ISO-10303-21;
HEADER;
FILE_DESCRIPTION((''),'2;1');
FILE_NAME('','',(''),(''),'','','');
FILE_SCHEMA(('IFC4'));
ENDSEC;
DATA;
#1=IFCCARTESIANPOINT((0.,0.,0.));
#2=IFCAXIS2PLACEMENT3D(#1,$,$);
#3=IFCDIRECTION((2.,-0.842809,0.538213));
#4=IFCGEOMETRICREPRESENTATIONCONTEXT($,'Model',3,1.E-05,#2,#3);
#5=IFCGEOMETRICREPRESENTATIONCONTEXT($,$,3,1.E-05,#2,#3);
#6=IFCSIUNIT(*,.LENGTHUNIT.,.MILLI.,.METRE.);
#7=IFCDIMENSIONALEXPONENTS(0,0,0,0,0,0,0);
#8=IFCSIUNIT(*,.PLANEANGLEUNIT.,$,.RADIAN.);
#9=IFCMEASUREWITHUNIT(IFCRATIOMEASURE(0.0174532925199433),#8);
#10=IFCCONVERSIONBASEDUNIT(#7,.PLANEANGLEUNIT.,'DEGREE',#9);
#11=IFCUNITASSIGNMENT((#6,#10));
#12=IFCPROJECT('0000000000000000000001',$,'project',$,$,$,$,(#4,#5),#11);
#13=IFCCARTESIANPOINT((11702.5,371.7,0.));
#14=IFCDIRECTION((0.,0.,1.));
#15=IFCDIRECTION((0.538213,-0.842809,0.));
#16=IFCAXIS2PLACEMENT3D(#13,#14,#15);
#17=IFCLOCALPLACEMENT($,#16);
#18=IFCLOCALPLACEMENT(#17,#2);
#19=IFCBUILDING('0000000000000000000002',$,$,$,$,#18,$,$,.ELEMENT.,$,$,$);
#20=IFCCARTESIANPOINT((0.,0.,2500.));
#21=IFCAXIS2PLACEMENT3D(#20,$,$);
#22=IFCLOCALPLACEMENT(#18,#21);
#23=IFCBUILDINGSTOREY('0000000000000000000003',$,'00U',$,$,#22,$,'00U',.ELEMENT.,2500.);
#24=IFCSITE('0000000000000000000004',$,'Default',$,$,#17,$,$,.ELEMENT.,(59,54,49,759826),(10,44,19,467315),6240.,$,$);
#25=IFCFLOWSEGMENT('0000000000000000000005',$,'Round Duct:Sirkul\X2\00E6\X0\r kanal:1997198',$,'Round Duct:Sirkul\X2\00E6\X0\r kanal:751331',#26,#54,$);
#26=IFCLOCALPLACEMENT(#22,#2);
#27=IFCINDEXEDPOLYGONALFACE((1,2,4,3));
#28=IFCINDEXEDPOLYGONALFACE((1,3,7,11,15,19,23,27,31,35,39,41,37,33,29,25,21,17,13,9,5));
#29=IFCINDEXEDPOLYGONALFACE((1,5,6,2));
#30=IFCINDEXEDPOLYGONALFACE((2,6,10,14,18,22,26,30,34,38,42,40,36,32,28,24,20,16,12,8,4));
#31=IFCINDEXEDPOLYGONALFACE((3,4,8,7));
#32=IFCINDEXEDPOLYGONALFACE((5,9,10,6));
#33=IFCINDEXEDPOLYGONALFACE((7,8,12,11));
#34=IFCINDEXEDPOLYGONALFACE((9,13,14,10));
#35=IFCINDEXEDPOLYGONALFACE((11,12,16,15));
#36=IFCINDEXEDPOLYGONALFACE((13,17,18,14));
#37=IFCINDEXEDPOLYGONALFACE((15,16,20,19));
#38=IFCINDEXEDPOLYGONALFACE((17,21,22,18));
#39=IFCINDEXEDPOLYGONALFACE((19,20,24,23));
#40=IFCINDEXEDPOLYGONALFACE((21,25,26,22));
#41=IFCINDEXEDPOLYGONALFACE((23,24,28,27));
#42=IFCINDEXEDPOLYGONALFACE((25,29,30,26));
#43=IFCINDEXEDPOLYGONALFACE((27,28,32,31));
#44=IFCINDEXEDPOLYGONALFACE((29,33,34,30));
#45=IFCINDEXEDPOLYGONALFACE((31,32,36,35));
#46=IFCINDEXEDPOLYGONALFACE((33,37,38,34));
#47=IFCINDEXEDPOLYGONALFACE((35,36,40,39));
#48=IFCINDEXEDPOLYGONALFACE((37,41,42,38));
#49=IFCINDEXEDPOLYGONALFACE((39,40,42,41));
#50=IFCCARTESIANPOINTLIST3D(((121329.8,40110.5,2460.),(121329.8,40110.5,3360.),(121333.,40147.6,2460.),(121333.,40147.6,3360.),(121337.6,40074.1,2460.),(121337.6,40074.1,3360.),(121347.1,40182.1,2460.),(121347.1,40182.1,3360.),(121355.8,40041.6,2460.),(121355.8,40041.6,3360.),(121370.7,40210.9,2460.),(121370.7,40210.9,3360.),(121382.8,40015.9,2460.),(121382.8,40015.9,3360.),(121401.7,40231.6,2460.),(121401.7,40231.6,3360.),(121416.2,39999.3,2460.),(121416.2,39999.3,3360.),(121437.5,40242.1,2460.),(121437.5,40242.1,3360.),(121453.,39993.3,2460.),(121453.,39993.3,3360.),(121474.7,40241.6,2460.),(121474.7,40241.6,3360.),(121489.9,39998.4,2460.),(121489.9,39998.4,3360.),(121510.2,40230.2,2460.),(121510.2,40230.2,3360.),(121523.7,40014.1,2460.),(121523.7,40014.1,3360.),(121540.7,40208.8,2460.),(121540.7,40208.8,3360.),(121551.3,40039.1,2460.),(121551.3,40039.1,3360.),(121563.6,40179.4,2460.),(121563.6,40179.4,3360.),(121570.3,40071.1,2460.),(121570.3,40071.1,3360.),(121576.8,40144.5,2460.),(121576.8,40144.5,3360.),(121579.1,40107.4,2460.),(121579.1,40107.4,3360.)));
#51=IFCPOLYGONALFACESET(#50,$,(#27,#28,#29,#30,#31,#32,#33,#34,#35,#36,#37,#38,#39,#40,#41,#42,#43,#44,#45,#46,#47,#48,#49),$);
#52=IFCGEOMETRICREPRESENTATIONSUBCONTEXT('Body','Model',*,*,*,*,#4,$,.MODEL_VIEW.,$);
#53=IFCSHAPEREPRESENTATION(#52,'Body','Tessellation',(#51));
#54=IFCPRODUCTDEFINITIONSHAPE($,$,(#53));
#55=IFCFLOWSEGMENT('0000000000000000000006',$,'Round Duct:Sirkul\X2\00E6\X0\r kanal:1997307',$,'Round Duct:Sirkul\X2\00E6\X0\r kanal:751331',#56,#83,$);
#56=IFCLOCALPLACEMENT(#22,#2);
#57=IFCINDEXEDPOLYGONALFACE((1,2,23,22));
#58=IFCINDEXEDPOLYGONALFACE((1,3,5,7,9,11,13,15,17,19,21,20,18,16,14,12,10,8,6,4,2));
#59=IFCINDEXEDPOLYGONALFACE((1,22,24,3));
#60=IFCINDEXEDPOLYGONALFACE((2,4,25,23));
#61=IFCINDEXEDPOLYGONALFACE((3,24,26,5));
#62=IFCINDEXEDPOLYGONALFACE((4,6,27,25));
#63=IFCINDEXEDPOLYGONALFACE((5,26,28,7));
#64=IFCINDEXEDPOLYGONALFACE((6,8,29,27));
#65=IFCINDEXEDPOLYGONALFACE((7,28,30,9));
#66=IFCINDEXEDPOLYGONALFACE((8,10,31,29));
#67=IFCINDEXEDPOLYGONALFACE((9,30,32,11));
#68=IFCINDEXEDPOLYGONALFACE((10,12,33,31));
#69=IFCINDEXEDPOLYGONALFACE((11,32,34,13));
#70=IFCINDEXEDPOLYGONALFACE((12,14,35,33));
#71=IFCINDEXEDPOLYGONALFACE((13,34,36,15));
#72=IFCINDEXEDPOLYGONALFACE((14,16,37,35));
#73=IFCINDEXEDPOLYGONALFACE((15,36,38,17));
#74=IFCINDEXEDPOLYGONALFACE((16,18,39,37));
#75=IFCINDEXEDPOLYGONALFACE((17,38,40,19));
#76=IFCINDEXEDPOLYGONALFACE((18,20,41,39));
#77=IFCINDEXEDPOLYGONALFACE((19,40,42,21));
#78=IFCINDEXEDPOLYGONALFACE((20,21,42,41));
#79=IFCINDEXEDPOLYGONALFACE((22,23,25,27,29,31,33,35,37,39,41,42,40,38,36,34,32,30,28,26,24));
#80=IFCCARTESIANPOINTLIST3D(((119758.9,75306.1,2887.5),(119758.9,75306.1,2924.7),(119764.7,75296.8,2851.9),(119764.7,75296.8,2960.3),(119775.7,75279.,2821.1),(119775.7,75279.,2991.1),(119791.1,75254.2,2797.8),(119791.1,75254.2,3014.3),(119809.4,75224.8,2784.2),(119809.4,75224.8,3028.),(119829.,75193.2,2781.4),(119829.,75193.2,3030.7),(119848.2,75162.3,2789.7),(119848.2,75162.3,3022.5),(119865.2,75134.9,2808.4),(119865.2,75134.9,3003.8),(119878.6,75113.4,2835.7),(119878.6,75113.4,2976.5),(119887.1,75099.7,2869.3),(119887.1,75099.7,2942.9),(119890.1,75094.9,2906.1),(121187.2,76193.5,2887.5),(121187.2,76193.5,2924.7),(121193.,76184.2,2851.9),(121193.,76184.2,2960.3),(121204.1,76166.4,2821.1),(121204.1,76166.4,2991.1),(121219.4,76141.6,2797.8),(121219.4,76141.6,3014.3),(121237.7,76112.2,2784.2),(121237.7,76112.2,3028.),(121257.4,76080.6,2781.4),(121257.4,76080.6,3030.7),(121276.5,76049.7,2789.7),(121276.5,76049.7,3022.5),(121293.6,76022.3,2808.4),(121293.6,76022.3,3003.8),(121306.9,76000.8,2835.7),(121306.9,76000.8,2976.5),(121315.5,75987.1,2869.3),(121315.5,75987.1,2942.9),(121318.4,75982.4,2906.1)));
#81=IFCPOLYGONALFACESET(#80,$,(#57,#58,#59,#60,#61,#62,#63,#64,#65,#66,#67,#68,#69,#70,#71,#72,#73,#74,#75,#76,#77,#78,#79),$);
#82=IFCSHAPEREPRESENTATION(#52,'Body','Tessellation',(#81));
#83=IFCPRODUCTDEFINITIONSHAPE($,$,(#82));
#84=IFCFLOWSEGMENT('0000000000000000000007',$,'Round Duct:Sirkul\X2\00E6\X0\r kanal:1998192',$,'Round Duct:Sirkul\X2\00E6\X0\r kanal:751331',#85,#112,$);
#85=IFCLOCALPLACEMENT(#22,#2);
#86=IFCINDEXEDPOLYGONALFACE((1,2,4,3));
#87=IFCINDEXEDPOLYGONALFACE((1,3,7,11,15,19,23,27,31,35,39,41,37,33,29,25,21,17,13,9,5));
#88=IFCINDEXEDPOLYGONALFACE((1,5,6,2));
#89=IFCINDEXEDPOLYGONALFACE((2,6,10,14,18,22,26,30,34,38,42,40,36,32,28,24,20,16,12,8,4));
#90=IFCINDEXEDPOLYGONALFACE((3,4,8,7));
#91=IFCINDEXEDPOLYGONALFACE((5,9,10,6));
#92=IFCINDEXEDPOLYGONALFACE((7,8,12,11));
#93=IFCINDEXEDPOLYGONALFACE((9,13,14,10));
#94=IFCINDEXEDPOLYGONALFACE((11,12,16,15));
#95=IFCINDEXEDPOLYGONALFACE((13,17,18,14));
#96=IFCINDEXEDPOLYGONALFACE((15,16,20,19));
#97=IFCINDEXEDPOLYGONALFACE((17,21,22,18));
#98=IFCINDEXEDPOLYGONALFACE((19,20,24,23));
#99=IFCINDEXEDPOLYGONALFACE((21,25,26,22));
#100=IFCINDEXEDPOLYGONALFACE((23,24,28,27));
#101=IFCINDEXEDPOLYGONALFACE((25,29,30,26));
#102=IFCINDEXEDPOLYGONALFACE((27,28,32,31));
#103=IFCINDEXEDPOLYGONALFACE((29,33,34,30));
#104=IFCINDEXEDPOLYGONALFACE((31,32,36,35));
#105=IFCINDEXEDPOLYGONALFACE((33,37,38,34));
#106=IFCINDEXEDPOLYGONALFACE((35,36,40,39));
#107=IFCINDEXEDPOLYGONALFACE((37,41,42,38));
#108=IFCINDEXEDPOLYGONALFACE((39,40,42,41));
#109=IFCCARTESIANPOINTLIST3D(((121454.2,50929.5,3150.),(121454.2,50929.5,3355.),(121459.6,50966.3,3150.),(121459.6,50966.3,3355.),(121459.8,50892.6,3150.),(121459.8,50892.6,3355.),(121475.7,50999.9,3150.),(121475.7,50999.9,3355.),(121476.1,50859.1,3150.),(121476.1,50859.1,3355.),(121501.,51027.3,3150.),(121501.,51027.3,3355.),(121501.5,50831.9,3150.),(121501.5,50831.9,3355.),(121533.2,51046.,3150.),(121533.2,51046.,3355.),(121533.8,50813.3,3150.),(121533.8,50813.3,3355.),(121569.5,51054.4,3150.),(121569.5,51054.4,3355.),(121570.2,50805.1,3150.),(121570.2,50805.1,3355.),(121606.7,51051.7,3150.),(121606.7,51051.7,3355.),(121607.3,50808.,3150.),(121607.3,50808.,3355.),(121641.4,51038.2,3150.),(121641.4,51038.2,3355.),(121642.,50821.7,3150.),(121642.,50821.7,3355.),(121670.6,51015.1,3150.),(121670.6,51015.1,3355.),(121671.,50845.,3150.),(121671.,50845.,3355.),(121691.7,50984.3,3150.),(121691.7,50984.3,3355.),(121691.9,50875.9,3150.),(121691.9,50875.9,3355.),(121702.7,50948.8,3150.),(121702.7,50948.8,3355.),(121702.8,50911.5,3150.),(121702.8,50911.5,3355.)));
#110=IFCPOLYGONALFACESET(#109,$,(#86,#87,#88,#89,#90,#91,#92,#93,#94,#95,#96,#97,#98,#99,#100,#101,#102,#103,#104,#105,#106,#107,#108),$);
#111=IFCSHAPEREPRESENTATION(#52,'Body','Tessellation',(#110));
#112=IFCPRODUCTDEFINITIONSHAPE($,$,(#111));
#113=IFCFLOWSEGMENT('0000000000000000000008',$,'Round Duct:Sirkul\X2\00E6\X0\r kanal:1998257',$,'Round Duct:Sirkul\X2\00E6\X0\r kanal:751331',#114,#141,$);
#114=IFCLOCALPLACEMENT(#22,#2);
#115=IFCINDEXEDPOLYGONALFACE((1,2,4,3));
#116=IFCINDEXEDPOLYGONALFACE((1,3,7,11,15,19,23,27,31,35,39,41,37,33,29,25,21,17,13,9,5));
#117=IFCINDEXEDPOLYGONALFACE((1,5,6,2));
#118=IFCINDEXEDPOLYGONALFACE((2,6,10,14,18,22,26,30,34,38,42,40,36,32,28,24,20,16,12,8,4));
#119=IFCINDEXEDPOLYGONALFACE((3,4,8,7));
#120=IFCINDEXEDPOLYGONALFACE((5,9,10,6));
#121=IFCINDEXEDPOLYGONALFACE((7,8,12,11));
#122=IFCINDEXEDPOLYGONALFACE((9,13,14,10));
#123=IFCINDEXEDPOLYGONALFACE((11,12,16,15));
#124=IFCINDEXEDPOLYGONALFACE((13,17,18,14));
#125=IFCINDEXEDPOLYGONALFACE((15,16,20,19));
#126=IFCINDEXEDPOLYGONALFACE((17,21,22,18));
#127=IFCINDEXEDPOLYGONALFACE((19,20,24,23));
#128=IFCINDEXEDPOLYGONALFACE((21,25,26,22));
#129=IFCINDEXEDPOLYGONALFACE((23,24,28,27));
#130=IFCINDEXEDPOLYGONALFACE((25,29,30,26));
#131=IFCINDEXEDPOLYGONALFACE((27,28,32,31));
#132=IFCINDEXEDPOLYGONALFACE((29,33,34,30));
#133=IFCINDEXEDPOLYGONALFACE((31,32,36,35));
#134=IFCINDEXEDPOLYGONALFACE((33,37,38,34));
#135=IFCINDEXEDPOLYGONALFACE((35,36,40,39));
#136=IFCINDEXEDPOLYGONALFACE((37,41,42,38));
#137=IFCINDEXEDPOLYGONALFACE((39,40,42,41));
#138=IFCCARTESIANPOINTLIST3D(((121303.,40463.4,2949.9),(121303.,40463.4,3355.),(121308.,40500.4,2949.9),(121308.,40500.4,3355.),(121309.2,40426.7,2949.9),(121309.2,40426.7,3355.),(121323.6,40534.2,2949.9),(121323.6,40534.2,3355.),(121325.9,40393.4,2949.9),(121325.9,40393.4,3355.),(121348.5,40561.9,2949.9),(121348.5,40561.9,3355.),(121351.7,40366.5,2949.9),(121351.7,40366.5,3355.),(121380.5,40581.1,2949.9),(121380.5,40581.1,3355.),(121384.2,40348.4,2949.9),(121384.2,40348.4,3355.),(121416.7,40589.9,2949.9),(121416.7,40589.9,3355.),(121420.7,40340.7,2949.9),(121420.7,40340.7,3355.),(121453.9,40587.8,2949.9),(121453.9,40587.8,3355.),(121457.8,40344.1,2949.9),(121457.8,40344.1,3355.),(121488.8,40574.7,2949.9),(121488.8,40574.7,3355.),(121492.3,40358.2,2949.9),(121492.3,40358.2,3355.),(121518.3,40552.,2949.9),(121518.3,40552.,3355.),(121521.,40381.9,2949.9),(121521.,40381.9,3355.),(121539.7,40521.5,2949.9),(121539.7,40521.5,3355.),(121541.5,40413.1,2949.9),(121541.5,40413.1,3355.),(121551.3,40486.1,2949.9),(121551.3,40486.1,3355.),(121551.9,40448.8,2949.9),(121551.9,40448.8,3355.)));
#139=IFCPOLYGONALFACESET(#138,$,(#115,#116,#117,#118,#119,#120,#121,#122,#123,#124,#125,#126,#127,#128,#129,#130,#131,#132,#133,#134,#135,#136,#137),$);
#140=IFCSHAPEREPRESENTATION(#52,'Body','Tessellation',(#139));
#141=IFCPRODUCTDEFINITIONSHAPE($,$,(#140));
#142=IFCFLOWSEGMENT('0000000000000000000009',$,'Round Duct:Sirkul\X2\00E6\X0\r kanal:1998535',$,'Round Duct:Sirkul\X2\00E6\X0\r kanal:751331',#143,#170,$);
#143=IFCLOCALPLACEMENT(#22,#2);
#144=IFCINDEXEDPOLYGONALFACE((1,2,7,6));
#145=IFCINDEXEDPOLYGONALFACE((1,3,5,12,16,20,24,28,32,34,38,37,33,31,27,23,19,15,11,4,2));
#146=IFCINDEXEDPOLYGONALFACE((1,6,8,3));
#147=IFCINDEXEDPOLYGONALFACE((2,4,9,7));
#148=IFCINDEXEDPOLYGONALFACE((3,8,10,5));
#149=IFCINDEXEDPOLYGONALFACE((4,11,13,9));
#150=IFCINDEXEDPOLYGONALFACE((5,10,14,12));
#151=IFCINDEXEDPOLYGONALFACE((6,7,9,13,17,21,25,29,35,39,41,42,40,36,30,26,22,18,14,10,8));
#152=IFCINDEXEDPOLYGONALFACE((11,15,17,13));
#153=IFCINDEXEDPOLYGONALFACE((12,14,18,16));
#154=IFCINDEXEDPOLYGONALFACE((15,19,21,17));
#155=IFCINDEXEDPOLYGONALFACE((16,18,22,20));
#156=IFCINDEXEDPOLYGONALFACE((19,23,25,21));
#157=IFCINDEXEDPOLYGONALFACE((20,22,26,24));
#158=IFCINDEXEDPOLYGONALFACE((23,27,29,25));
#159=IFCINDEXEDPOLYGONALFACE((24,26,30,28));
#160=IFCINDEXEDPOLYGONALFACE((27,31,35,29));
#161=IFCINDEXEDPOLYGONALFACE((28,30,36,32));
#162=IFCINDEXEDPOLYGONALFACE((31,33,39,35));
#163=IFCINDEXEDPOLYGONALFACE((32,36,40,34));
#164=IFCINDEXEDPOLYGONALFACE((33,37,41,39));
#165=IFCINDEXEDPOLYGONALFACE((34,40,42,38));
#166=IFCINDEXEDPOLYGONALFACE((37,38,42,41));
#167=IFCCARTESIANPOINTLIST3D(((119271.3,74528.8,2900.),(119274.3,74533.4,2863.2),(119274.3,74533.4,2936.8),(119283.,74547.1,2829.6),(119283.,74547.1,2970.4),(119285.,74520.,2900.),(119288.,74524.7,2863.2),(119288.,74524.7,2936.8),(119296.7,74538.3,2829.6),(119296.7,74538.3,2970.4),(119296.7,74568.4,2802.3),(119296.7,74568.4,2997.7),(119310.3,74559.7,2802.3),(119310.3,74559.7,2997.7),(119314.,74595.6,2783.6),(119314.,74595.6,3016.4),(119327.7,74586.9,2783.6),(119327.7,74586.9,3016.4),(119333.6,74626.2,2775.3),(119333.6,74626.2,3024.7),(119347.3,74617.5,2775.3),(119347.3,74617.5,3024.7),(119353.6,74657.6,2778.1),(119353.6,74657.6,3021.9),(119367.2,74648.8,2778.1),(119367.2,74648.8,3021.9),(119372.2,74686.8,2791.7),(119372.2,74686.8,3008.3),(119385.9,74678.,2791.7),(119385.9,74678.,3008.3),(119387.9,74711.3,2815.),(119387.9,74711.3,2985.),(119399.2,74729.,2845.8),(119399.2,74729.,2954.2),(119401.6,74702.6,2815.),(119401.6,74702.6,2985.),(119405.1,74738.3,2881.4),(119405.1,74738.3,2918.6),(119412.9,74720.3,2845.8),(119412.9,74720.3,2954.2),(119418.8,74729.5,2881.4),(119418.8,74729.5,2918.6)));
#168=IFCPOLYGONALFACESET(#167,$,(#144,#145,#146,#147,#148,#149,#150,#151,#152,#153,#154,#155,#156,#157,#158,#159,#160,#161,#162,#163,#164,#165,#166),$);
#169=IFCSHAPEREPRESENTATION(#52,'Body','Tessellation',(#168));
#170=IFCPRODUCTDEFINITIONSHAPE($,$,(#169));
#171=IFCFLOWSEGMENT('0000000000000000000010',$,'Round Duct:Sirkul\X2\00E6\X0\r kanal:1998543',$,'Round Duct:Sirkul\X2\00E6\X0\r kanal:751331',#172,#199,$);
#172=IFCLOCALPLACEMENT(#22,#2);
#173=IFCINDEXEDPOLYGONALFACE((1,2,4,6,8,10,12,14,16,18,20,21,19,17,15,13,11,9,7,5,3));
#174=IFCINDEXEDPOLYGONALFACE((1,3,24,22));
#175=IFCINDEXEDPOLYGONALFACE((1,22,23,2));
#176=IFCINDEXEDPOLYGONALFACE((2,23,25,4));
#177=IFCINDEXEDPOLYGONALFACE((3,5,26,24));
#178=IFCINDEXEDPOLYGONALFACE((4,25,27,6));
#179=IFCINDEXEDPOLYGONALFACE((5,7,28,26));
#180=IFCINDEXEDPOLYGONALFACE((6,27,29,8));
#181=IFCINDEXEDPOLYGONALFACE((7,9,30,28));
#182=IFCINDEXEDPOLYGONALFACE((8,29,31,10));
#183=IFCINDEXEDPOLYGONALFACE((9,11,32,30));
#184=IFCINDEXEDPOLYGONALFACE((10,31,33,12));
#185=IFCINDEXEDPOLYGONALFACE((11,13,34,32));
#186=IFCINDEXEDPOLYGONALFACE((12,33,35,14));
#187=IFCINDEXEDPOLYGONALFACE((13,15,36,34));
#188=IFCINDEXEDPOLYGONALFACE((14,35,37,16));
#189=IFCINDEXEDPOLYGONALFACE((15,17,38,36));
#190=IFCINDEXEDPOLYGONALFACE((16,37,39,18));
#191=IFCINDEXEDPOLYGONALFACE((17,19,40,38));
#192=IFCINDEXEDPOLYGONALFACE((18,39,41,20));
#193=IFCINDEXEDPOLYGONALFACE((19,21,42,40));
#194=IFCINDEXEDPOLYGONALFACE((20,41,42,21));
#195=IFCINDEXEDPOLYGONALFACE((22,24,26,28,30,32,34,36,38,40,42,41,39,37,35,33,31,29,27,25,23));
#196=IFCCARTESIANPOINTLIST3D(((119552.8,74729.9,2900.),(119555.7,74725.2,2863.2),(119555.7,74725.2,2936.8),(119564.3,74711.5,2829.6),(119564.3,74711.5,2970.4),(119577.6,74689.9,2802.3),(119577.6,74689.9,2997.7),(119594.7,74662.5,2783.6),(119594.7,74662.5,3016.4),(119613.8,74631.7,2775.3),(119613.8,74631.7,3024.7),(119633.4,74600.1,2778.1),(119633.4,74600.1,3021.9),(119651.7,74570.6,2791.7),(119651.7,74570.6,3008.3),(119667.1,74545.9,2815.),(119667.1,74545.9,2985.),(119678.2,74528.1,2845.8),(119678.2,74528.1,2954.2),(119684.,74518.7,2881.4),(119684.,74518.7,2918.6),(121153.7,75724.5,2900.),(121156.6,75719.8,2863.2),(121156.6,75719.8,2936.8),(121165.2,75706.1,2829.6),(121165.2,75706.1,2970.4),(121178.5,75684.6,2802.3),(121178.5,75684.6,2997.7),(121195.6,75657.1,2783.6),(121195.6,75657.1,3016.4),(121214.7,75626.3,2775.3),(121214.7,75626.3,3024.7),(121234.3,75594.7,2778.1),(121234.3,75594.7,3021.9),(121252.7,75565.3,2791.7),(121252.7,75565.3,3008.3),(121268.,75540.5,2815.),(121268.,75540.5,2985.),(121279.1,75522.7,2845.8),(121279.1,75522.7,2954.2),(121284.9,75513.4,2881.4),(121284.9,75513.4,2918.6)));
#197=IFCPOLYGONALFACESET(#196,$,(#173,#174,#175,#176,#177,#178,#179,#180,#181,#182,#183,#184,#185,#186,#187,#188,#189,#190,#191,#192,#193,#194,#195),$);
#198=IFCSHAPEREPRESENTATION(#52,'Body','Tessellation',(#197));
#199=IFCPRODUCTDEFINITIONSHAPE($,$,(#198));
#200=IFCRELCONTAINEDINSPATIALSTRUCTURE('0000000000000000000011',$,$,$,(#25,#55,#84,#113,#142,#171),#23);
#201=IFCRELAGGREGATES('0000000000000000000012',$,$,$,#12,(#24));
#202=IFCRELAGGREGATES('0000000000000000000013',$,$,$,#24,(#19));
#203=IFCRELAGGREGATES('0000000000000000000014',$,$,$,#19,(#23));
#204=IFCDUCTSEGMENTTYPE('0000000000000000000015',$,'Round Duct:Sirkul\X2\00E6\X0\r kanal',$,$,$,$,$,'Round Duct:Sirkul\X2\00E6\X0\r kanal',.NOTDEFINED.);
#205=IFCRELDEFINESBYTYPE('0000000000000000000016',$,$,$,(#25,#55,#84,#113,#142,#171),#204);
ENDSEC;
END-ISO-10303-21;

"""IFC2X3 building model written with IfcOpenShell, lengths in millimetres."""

from ifc_helpers import new_model, entity, si_unit, converted_unit, direction, frame, frame_2d, origin, origin_2d_with_axis, place, context, subcontext, project, spatial, circle, extrude, type_object, element, save


model = new_model("IFC2X3")

# Units and contexts
model_context = context("Model", 3, precision=1e-05, world=origin(), true_north=direction((2.0, -0.842809, 0.538213)))
context_of_model = context(None, 3, precision=1e-05, world=origin(), true_north=direction((2.0, -0.842809, 0.538213)))
body_context = subcontext(model_context, "Body", "Model", "MODEL_VIEW")
ifc_project = project(units=[si_unit("LENGTHUNIT", "METRE", prefix="MILLI"), converted_unit("PLANEANGLEUNIT", "DEGREE", entity("IfcRatioMeasure", 0.0174532925199433), si_unit("PLANEANGLEUNIT", "RADIAN"), dimensions=[0, 0, 0, 0, 0, 0, 0])], contexts=[model_context, context_of_model])

# Site, building, storey
site_placement = place(None, frame((11702.5, 371.7, 0.0), z_axis=(0.0, 0.0, 1.0), x_axis=(0.538213, -0.842809, 0.0)))
site = spatial("IfcSite", under=ifc_project, at=site_placement, Name="Default", CompositionType="ELEMENT", RefLatitude=(59, 54, 49, 759826), RefLongitude=(10, 44, 19, 467315), RefElevation=6240.0)
building_placement = place(site_placement, origin())
building = spatial("IfcBuilding", under=site, at=building_placement, CompositionType="ELEMENT")
storey_placement = place(building_placement, frame((0.0, 0.0, 2500.0)))
storey = spatial("IfcBuildingStorey", under=building, at=storey_placement, Name="00U", LongName="00U", CompositionType="ELEMENT", Elevation=2500.0)

# Flow segments
duct_segment_type_1 = type_object("IfcDuctSegmentType", Name="Round Duct:Sirkulær kanal", ElementType="Round Duct:Sirkulær kanal", PredefinedType="NOTDEFINED")
flow_segment_1_placement = place(storey_placement, origin())
element("IfcFlowSegment", 1, at=flow_segment_1_placement, inside=storey, type_object=duct_segment_type_1, Name="Round Duct:Sirkulær kanal:1997198", ObjectType="Round Duct:Sirkulær kanal:751331", context=body_context, shape_type="SweptSolid", body=[
    extrude(circle(Radius=125.0, at=frame_2d((0.0, 0.0), x_axis=(1.0, 0.0))), frame((121454.5, 40118.3, 2460.0), z_axis=(0.0, 0.0, 1.0), x_axis=(-0.13662, 0.990623, 0.0)), (0.0, 0.0, 1.0), 900.0),
])
flow_segment_2_placement = place(storey_placement, origin())
element("IfcFlowSegment", 2, at=flow_segment_2_placement, inside=storey, type_object=duct_segment_type_1, Name="Round Duct:Sirkulær kanal:1997307", ObjectType="Round Duct:Sirkulær kanal:751331", context=body_context, shape_type="SweptSolid", body=[
    extrude(circle(Radius=125.0, at=origin_2d_with_axis()), frame((119824.1, 75201.1, 2906.1), z_axis=(0.849411, 0.527732, 0.0), x_axis=(0.527732, -0.849411, 0.0)), (0.0, 0.0, 1.0), 1681.6),
])
flow_segment_3_placement = place(storey_placement, origin())
element("IfcFlowSegment", 3, at=flow_segment_3_placement, inside=storey, type_object=duct_segment_type_1, Name="Round Duct:Sirkulær kanal:1998192", ObjectType="Round Duct:Sirkulær kanal:751331", context=body_context, shape_type="SweptSolid", body=[
    extrude(circle(Radius=125.0, at=origin_2d_with_axis()), frame((121579.2, 50929.8, 3150.0), z_axis=(0.0, 0.0, 1.0), x_axis=(-0.077379, 0.997002, 0.0)), (0.0, 0.0, 1.0), 205.0),
])
flow_segment_4_placement = place(storey_placement, origin())
element("IfcFlowSegment", 4, at=flow_segment_4_placement, inside=storey, type_object=duct_segment_type_1, Name="Round Duct:Sirkulær kanal:1998257", ObjectType="Round Duct:Sirkulær kanal:751331", context=body_context, shape_type="SweptSolid", body=[
    extrude(circle(Radius=125.0, at=frame_2d((0.0, 0.0), x_axis=(1.0, 0.0))), frame((121428.0, 40465.5, 2949.9), z_axis=(0.0, 0.0, 1.0), x_axis=(0.986284, 0.165059, 0.0)), (0.0, 0.0, 1.0), 405.1),
])
flow_segment_5_placement = place(storey_placement, origin())
element("IfcFlowSegment", 5, at=flow_segment_5_placement, inside=storey, type_object=duct_segment_type_1, Name="Round Duct:Sirkulær kanal:1998535", ObjectType="Round Duct:Sirkulær kanal:751331", context=body_context, shape_type="SweptSolid", body=[
    extrude(circle(Radius=125.0, at=origin_2d_with_axis()), frame((119352.3, 74625.4, 2900.0), z_axis=(-0.842809, 0.538213, 0.0), x_axis=(-0.538213, -0.842809, 0.0)), (0.0, 0.0, 1.0), 16.2),
])
flow_segment_6_placement = place(storey_placement, origin())
element("IfcFlowSegment", 6, at=flow_segment_6_placement, inside=storey, type_object=duct_segment_type_1, Name="Round Duct:Sirkulær kanal:1998543", ObjectType="Round Duct:Sirkulær kanal:751331", context=body_context, shape_type="SweptSolid", body=[
    extrude(circle(Radius=125.0, at=frame_2d((0.0, 0.0), x_axis=(1.0, 0.0))), frame((119618.8, 74623.7, 2900.0), z_axis=(0.849411, 0.527732, 0.0), x_axis=(-0.527732, 0.849411, 0.0)), (0.0, 0.0, 1.0), 1884.7),
])

save(model, "model.ifc")
